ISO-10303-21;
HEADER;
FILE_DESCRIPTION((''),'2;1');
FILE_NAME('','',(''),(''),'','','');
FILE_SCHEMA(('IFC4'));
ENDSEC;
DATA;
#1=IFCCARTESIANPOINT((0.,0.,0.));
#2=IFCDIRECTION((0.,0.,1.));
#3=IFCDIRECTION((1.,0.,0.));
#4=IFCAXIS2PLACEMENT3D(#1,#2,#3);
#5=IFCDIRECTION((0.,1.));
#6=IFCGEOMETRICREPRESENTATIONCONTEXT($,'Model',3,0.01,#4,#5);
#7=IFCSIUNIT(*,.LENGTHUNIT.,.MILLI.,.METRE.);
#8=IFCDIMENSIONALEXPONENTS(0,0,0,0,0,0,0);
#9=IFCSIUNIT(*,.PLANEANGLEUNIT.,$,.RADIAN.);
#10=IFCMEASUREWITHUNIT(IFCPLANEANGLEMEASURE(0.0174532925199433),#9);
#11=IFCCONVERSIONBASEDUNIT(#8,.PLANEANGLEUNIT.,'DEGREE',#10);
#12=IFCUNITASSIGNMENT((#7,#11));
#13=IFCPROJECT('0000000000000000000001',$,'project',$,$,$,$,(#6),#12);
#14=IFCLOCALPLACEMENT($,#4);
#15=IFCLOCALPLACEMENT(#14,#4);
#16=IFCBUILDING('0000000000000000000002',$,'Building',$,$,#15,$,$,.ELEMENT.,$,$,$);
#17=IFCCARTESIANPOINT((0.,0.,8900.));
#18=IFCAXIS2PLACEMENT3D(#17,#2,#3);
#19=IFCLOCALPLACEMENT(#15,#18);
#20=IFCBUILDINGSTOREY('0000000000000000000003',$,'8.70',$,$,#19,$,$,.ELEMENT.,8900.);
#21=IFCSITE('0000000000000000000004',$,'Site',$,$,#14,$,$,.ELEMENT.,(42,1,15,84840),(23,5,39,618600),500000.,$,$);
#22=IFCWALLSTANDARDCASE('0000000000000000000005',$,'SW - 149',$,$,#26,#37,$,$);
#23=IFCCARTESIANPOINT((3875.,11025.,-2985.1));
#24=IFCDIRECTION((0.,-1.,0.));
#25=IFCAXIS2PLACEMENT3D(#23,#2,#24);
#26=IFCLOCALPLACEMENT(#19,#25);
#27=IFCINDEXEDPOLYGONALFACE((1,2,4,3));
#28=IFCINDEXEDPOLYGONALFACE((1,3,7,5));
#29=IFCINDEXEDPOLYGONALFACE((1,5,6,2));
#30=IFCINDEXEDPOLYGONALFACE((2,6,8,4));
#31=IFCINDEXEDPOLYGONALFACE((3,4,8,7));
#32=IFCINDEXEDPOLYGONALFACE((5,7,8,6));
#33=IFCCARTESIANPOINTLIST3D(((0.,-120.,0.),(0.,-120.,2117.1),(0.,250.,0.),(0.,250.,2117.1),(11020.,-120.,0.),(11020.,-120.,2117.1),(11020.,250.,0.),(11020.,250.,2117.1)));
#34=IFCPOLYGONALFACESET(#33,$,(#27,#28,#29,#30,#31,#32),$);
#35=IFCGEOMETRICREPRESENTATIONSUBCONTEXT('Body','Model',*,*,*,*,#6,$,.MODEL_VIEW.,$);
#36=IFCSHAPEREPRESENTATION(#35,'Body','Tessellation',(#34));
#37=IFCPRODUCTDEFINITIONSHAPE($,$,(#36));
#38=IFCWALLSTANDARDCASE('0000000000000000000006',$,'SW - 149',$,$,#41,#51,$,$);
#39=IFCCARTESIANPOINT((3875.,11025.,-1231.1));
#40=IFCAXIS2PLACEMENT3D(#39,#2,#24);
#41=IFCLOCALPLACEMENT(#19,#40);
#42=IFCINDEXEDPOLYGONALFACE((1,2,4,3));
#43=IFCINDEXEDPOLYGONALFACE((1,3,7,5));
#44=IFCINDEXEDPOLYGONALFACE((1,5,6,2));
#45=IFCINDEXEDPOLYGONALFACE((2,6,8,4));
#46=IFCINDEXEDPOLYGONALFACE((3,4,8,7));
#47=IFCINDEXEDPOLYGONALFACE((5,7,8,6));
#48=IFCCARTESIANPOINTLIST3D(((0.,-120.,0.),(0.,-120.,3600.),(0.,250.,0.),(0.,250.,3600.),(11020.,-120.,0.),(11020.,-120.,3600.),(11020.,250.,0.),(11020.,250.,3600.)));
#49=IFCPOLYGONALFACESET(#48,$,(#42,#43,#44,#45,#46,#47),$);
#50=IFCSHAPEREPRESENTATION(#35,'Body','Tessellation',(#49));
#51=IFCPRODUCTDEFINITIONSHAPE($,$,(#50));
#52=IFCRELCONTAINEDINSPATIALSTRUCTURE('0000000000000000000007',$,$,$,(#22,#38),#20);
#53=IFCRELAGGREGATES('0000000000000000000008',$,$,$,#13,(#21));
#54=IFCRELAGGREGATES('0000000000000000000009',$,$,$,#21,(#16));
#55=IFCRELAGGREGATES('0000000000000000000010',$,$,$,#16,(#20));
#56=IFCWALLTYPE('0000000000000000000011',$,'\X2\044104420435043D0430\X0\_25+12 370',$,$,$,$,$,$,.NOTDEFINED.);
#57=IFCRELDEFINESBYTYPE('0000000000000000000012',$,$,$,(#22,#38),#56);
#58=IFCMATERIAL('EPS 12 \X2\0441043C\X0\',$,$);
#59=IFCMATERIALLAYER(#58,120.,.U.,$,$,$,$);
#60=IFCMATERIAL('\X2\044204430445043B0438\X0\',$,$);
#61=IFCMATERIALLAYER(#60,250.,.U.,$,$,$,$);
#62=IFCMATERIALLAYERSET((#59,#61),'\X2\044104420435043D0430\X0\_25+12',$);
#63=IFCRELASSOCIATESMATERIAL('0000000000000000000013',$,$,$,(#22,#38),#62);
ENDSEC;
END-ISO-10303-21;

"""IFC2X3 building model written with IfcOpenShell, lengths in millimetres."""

from ifc_helpers import new_model, entity, si_unit, converted_unit, direction, frame, origin_with_axes, place, context, subcontext, project, spatial, polyline, outline, extrude, material, layer, layer_set, layer_usage, type_object, element, save


model = new_model("IFC2X3")

# Units and contexts
model_context = context("Model", 3, precision=0.01, world=origin_with_axes(), true_north=direction((0.0, 1.0)))
body_context = subcontext(model_context, "Body", "Model", "MODEL_VIEW")
ifc_project = project(units=[si_unit("LENGTHUNIT", "METRE", prefix="MILLI"), converted_unit("PLANEANGLEUNIT", "DEGREE", entity("IfcPlaneAngleMeasure", 0.0174532925199433), si_unit("PLANEANGLEUNIT", "RADIAN"), dimensions=[0, 0, 0, 0, 0, 0, 0])], contexts=[model_context])

# Site, building, storey
site_placement = place(None, origin_with_axes())
site = spatial("IfcSite", under=ifc_project, at=site_placement, Name="Site", CompositionType="ELEMENT", RefLatitude=(42, 1, 15, 84840), RefLongitude=(23, 5, 39, 618600), RefElevation=500000.0)
building_placement = place(site_placement, origin_with_axes())
building = spatial("IfcBuilding", under=site, at=building_placement, Name="Building", CompositionType="ELEMENT")
storey_placement = place(building_placement, frame((0.0, 0.0, 8900.0), z_axis=(0.0, 0.0, 1.0), x_axis=(1.0, 0.0, 0.0)))
storey = spatial("IfcBuildingStorey", under=building, at=storey_placement, Name="8.70", CompositionType="ELEMENT", Elevation=8900.0)

# Walls
ifc_material_1 = material(Name="EPS 12 см")
ifc_layer_1 = layer(ifc_material_1, 120.0, ventilated="UNKNOWN")
ifc_material_2 = material(Name="тухли")
ifc_layer_2 = layer(ifc_material_2, 250.0, ventilated="UNKNOWN")
ifc_layer_set_1 = layer_set([ifc_layer_1, ifc_layer_2], Name="стена_25+12")
ifc_layer_usage_1 = layer_usage(ifc_layer_set_1, "AXIS2", "POSITIVE", -120.0)
wall_type = type_object("IfcWallType", Name="стена_25+12 370", PredefinedType="NOTDEFINED")
wall_1_placement = place(storey_placement, frame((3875.0, 11025.0, -2985.1), z_axis=(0.0, 0.0, 1.0), x_axis=(0.0, -1.0, 0.0)))
element("IfcWallStandardCase", 1, at=wall_1_placement, inside=storey, type_object=wall_type, material=ifc_layer_usage_1, Name="SW - 149", context=body_context, shape_type="SweptSolid", body=[
    extrude(outline(polyline([(0.0, -120.0), (11020.0, -120.0), (11020.0, 250.0), (0.0, 250.0), (0.0, -120.0)])), origin_with_axes(), (0.0, 0.0, 1.0), 2117.1),
])
ifc_layer_usage_2 = layer_usage(ifc_layer_set_1, "AXIS2", "POSITIVE", -120.0)
wall_2_placement = place(storey_placement, frame((3875.0, 11025.0, -1231.1), z_axis=(0.0, 0.0, 1.0), x_axis=(0.0, -1.0, 0.0)))
element("IfcWallStandardCase", 2, at=wall_2_placement, inside=storey, type_object=wall_type, material=ifc_layer_usage_2, Name="SW - 149", context=body_context, shape_type="SweptSolid", body=[
    extrude(outline(polyline([(0.0, -120.0), (11020.0, -120.0), (11020.0, 250.0), (0.0, 250.0), (0.0, -120.0)])), origin_with_axes(), (0.0, 0.0, 1.0), 3600.0),
])

save(model, "model.ifc")
